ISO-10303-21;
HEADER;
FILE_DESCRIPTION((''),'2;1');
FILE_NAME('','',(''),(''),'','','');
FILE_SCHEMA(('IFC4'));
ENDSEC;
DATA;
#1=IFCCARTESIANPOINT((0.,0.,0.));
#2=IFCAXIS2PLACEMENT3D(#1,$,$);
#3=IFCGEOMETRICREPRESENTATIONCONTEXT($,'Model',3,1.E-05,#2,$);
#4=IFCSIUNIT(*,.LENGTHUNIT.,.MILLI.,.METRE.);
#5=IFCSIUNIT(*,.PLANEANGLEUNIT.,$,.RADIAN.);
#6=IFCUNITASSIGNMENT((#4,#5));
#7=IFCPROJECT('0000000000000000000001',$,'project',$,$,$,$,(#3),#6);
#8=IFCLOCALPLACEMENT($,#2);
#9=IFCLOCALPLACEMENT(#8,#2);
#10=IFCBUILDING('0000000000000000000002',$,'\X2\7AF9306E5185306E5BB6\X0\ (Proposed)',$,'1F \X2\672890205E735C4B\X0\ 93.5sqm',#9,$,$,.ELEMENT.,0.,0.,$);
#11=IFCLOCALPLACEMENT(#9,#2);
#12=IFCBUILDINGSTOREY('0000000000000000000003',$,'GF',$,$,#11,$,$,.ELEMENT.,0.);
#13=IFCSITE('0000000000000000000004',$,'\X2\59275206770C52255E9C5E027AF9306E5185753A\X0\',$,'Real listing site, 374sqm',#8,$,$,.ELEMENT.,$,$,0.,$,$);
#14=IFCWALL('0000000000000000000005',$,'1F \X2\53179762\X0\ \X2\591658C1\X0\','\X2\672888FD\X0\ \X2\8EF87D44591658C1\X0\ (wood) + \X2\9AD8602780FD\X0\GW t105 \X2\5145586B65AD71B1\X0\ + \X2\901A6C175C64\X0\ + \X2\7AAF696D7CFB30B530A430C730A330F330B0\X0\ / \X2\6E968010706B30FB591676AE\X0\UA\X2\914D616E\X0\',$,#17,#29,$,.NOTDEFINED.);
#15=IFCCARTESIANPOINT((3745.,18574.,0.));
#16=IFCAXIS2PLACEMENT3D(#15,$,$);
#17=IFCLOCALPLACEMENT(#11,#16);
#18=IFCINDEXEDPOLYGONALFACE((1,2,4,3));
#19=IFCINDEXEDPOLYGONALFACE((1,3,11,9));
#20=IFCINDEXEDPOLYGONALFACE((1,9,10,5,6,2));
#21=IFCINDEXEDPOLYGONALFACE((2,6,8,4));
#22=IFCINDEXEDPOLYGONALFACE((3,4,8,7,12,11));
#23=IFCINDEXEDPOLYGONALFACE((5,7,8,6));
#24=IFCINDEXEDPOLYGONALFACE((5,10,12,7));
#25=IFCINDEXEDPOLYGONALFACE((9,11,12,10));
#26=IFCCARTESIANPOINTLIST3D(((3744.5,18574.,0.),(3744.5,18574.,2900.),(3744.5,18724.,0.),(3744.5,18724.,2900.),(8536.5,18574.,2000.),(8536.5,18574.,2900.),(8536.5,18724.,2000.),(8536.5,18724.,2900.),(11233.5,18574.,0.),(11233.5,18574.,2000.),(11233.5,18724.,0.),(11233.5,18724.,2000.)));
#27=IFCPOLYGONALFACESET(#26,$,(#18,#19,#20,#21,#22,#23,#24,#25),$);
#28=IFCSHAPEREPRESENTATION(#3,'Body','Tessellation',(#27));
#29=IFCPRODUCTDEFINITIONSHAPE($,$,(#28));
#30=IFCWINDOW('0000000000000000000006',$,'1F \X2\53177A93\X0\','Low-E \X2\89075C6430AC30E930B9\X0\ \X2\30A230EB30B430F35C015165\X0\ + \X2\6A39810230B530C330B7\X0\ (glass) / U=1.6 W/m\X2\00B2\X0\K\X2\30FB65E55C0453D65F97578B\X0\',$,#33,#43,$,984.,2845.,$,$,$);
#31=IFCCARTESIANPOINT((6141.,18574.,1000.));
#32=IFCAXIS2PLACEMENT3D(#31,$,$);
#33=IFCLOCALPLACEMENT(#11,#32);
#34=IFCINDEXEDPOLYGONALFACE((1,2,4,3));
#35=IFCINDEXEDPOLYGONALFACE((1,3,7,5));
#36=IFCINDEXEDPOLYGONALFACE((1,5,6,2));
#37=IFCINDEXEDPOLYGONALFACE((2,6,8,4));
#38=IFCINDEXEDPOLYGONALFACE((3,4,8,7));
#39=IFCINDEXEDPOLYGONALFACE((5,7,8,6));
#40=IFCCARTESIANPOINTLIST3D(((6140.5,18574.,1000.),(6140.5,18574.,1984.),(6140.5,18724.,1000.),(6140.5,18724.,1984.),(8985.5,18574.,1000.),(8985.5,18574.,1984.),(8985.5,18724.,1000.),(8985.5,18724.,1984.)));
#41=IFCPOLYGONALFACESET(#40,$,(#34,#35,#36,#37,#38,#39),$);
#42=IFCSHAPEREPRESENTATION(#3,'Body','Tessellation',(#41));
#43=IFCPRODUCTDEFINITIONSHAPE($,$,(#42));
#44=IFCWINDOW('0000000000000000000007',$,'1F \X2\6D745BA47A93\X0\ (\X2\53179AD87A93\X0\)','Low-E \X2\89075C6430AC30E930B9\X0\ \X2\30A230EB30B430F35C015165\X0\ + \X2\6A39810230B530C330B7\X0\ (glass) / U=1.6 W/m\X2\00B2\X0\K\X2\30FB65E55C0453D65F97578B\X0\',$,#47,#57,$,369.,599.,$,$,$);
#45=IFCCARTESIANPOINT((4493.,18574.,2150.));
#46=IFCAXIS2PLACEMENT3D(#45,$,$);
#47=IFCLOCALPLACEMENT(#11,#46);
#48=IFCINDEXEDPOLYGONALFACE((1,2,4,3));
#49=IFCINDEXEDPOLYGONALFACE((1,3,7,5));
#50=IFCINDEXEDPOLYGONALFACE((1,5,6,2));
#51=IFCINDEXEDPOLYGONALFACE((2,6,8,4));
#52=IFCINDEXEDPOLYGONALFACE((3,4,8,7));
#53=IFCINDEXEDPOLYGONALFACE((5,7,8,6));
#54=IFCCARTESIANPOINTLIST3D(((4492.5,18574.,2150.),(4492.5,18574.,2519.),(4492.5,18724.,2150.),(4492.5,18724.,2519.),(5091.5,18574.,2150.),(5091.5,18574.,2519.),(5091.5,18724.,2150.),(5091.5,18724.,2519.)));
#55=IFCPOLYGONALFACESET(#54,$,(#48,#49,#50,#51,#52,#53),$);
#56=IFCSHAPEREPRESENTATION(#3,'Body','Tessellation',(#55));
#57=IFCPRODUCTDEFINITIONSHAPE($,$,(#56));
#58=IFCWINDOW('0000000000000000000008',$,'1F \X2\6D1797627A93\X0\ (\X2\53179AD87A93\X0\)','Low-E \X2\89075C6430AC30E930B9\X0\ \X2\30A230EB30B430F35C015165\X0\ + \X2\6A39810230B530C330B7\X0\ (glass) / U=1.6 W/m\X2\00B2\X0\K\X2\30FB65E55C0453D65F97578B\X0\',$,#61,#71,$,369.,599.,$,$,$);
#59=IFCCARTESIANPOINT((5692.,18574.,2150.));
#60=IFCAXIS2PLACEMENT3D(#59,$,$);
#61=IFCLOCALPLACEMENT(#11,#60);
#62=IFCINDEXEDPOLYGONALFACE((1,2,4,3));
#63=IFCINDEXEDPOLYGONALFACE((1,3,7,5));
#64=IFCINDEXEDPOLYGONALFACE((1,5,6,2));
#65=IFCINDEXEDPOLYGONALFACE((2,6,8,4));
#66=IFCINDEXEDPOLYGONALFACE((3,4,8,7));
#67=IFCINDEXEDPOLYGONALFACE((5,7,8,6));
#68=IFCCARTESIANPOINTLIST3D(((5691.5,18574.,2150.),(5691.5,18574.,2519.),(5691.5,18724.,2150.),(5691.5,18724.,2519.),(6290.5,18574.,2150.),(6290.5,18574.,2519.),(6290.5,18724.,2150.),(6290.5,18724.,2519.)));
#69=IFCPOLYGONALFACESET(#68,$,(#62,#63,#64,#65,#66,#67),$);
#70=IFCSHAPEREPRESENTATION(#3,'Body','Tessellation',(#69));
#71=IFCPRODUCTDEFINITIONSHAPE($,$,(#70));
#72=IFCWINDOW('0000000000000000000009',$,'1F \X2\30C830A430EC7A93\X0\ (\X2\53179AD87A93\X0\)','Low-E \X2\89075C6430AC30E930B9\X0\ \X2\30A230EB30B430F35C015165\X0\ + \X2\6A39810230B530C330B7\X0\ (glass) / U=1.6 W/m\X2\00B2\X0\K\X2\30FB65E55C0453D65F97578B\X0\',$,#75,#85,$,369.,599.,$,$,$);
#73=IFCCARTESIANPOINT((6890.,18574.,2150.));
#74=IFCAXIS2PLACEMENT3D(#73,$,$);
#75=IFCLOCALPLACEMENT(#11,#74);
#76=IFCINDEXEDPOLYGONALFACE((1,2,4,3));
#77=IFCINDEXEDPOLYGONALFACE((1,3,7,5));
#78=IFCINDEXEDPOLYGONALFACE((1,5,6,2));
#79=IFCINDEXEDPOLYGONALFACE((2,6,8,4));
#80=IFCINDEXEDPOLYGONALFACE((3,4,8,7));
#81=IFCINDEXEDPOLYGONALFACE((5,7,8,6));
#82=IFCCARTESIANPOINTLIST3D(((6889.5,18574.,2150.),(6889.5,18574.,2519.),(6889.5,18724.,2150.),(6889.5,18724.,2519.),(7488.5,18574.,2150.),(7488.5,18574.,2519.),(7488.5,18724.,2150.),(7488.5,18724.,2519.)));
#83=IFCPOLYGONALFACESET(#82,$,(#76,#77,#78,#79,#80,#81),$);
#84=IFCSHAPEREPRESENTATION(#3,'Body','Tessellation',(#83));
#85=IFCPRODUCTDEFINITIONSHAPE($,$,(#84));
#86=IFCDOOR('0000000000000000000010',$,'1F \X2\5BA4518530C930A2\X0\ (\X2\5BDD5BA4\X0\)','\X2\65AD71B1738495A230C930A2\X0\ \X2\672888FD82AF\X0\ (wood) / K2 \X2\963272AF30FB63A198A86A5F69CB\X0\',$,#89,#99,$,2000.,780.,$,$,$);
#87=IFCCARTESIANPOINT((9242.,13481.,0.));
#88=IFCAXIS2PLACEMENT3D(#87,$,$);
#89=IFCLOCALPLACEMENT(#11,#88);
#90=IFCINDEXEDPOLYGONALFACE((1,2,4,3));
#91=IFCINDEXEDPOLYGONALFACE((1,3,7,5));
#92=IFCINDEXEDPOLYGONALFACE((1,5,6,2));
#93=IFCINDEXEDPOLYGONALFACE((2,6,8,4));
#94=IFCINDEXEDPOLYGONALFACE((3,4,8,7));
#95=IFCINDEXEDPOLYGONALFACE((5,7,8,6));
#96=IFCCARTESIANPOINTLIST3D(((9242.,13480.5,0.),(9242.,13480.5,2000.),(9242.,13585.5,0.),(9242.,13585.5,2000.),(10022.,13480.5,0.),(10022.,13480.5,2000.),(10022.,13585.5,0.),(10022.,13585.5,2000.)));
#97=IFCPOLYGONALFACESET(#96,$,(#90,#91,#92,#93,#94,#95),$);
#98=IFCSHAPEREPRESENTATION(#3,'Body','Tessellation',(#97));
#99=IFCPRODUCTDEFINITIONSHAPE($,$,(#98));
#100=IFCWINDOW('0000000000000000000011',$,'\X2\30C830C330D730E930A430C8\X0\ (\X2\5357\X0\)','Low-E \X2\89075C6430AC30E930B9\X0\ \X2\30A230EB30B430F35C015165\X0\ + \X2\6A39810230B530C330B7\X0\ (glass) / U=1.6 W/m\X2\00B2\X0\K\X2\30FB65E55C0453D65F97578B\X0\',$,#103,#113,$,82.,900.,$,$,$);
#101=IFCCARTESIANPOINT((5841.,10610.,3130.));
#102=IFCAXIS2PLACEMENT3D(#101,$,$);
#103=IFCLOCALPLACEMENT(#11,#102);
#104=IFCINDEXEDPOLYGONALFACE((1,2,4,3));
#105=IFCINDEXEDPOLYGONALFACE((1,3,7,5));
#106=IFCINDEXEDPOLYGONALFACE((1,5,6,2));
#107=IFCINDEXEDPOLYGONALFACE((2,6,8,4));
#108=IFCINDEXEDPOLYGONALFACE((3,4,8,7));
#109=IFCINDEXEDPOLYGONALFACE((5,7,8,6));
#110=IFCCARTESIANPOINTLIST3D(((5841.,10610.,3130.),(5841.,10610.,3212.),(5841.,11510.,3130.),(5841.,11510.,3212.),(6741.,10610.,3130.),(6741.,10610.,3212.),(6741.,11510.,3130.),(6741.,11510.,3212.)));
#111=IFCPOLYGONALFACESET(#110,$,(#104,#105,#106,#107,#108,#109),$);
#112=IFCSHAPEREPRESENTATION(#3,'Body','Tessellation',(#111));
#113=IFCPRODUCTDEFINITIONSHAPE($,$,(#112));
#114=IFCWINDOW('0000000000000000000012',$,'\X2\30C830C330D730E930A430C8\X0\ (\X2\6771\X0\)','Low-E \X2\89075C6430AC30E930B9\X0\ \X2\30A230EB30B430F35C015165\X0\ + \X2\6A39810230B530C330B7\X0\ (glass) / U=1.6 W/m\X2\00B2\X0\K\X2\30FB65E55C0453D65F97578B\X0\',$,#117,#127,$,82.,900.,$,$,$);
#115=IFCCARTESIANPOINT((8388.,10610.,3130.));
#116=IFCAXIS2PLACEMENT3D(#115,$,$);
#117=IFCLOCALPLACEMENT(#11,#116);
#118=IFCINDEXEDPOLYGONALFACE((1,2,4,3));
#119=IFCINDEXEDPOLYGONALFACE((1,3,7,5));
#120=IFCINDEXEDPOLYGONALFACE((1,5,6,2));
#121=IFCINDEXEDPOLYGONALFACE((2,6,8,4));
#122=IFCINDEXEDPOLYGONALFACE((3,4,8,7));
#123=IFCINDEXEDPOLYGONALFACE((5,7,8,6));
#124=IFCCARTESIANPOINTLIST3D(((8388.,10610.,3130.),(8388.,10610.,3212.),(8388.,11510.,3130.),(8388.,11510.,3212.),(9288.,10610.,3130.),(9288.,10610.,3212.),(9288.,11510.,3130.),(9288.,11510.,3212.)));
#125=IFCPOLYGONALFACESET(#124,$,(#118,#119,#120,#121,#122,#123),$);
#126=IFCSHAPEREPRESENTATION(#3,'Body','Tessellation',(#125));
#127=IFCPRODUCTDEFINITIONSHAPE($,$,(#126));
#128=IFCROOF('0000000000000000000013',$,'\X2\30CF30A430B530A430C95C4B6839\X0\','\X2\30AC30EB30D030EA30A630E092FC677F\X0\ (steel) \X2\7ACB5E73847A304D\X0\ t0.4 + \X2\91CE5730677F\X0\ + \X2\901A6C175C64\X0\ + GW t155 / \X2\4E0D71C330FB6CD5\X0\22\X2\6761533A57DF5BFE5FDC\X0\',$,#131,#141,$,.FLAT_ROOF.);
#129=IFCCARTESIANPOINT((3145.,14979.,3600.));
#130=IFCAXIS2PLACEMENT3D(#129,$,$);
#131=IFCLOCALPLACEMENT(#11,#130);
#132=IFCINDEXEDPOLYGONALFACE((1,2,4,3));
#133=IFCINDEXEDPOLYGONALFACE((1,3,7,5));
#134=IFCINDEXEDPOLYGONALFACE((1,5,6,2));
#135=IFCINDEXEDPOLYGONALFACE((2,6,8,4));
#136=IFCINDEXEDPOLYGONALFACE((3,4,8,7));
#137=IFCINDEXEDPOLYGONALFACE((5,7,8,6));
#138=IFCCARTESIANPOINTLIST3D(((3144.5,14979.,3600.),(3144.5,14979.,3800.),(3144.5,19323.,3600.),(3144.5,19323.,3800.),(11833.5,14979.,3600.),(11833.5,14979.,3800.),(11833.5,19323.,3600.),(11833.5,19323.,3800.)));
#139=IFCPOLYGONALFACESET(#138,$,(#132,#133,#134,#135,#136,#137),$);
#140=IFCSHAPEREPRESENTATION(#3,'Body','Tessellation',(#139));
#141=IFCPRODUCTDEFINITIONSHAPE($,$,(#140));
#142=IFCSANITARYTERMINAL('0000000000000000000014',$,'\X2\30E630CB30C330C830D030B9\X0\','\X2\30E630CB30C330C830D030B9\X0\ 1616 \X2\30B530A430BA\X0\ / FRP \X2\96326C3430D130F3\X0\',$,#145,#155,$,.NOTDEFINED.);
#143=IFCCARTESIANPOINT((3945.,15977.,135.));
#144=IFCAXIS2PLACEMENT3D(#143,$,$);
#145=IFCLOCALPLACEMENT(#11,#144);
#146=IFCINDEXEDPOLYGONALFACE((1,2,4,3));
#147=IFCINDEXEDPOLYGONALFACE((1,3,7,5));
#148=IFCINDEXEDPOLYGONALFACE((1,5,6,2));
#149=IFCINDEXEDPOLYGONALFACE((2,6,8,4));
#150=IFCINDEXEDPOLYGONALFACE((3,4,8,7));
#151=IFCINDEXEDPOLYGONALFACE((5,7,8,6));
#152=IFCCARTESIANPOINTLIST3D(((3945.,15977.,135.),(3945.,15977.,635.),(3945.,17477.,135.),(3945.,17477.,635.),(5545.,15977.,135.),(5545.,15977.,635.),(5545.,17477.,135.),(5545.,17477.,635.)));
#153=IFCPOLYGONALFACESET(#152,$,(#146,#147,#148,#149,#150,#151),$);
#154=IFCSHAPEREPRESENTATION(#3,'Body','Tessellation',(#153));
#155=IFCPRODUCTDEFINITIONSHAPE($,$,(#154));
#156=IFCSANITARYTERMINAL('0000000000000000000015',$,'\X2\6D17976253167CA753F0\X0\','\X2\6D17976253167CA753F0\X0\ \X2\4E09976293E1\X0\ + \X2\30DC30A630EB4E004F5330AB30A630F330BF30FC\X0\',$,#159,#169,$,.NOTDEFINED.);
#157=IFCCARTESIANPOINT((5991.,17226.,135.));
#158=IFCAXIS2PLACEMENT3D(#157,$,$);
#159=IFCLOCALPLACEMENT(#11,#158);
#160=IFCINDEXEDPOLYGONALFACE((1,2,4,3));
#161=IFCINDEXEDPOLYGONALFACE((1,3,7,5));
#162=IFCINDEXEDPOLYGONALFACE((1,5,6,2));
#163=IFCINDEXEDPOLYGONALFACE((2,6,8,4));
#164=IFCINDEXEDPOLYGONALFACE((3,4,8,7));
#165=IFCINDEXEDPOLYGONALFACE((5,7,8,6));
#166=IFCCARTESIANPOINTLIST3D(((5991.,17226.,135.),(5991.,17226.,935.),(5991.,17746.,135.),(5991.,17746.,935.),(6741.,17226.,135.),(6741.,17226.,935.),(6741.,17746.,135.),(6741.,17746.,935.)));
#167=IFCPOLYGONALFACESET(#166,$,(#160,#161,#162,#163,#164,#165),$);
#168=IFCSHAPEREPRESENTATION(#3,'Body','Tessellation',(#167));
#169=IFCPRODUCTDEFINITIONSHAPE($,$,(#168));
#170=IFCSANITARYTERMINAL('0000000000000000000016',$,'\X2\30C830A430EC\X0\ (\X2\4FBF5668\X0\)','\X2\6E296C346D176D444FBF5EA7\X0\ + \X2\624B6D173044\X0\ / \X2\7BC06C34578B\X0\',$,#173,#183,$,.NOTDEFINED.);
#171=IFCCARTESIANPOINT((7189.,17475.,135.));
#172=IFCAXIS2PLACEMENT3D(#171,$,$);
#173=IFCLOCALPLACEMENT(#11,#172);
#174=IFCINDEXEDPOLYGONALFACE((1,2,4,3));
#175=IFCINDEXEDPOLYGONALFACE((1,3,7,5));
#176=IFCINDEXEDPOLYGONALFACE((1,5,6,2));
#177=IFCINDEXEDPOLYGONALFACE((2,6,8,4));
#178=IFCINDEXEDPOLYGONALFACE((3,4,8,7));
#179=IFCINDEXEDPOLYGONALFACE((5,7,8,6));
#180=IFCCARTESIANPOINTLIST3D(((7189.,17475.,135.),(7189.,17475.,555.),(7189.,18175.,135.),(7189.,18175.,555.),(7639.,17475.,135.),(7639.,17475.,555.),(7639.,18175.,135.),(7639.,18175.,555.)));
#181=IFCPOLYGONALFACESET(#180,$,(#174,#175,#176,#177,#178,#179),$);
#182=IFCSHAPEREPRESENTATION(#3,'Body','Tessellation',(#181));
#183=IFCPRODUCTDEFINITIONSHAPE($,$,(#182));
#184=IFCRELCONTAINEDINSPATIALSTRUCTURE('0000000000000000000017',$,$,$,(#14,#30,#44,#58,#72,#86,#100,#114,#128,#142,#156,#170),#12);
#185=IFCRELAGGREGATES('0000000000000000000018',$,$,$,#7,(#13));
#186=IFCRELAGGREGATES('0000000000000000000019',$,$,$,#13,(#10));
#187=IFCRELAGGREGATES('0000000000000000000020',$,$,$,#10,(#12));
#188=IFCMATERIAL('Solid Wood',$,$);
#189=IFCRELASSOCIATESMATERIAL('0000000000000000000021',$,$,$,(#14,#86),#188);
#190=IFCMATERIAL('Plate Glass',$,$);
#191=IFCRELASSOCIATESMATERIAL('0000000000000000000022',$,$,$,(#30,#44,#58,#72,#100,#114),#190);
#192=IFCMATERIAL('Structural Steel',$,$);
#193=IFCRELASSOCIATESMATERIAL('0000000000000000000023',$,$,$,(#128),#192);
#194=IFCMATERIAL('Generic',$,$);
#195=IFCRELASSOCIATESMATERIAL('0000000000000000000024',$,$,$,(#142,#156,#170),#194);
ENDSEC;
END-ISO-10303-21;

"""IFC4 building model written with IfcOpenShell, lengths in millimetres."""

from ifc_helpers import new_model, si_unit, frame, frame_2d, origin, place, context, project, spatial, rectangle, extrude, material, element, fill, save


model = new_model("IFC4")

# Units and contexts
model_context = context("Model", 3, precision=1e-05, world=origin())
ifc_project = project(units=[si_unit("LENGTHUNIT", "METRE", prefix="MILLI"), si_unit("PLANEANGLEUNIT", "RADIAN")], contexts=[model_context])

# Site, building, storey
site_placement = place(None, origin())
site = spatial("IfcSite", under=ifc_project, at=site_placement, Name="大分県別府市竹の内町", ObjectType="Real listing site, 374sqm", CompositionType="ELEMENT", RefElevation=0.0)
building_placement = place(site_placement, origin())
building = spatial("IfcBuilding", under=site, at=building_placement, Name="竹の内の家 (Proposed)", ObjectType="1F 木造平屋 93.5sqm", CompositionType="ELEMENT", ElevationOfRefHeight=0.0, ElevationOfTerrain=0.0)
storey_placement = place(building_placement, origin())
storey = spatial("IfcBuildingStorey", under=building, at=storey_placement, Name="GF", CompositionType="ELEMENT", Elevation=0.0)

# Shared definitions
ifc_material_1 = material(Name="Solid Wood")

# Wall, openings, windows
wall_1_placement = place(storey_placement, frame((3745.0, 18574.0, 0.0)))
wall_1 = element("IfcWall", 1, at=wall_1_placement, inside=storey, material=ifc_material_1, Name="1F 北面 外壁", Description="木製 軸組外壁 (wood) + 高性能GW t105 充填断熱 + 通気層 + 窯業系サイディング / 準耐火・外皮UA配慮", PredefinedType="NOTDEFINED", context=model_context, shape_type="SweptSolid", body=[
    extrude(rectangle(XDim=7489.0, YDim=150.0, at=frame_2d((3744.0, 75.0))), frame((3745.0, 18574.0, 0.0)), (0.0, 0.0, 1.0), 2900.0),
])
opening_1_placement = place(storey_placement, frame((6141.0, 18574.0, 1000.0)))
opening_1 = element("IfcOpeningElement", 2, at=opening_1_placement, cuts=wall_1, PredefinedType="NOTDEFINED", context=model_context, shape_type="SweptSolid", body=[
    extrude(rectangle(XDim=2845.0, YDim=150.0, at=frame_2d((1422.0, 75.0))), frame((6141.0, 18574.0, 1000.0)), (0.0, 0.0, 1.0), 984.0),
])
opening_2_placement = place(storey_placement, frame((4493.0, 18574.0, 2150.0)))
opening_2 = element("IfcOpeningElement", 3, at=opening_2_placement, cuts=wall_1, PredefinedType="NOTDEFINED", context=model_context, shape_type="SweptSolid", body=[
    extrude(rectangle(XDim=599.0, YDim=150.0, at=frame_2d((299.0, 75.0))), frame((4493.0, 18574.0, 2150.0)), (0.0, 0.0, 1.0), 369.0),
])
opening_3_placement = place(storey_placement, frame((5692.0, 18574.0, 2150.0)))
opening_3 = element("IfcOpeningElement", 4, at=opening_3_placement, cuts=wall_1, PredefinedType="NOTDEFINED", context=model_context, shape_type="SweptSolid", body=[
    extrude(rectangle(XDim=599.0, YDim=150.0, at=frame_2d((299.0, 75.0))), frame((5692.0, 18574.0, 2150.0)), (0.0, 0.0, 1.0), 369.0),
])
opening_4_placement = place(storey_placement, frame((6890.0, 18574.0, 2150.0)))
opening_4 = element("IfcOpeningElement", 5, at=opening_4_placement, cuts=wall_1, PredefinedType="NOTDEFINED", context=model_context, shape_type="SweptSolid", body=[
    extrude(rectangle(XDim=599.0, YDim=150.0, at=frame_2d((299.0, 75.0))), frame((6890.0, 18574.0, 2150.0)), (0.0, 0.0, 1.0), 369.0),
])
ifc_material_2 = material(Name="Plate Glass")
window_1_placement = place(storey_placement, frame((6141.0, 18574.0, 1000.0)))
window_1 = element("IfcWindow", 6, at=window_1_placement, inside=storey, material=ifc_material_2, Name="1F 北窓", Description="Low-E 複層ガラス アルゴン封入 + 樹脂サッシ (glass) / U=1.6 W/m²K・日射取得型", OverallHeight=984.0, OverallWidth=2845.0, context=model_context, shape_type="SweptSolid", body=[
    extrude(rectangle(XDim=2845.0, YDim=150.0, at=frame_2d((1422.0, 75.0))), frame((6141.0, 18574.0, 1000.0)), (0.0, 0.0, 1.0), 984.0),
])
fill(opening_1, window_1)
window_2_placement = place(storey_placement, frame((4493.0, 18574.0, 2150.0)))
window_2 = element("IfcWindow", 7, at=window_2_placement, inside=storey, material=ifc_material_2, Name="1F 浴室窓 (北高窓)", Description="Low-E 複層ガラス アルゴン封入 + 樹脂サッシ (glass) / U=1.6 W/m²K・日射取得型", OverallHeight=369.0, OverallWidth=599.0, context=model_context, shape_type="SweptSolid", body=[
    extrude(rectangle(XDim=599.0, YDim=150.0, at=frame_2d((299.0, 75.0))), frame((4493.0, 18574.0, 2150.0)), (0.0, 0.0, 1.0), 369.0),
])
fill(opening_2, window_2)
window_3_placement = place(storey_placement, frame((5692.0, 18574.0, 2150.0)))
window_3 = element("IfcWindow", 8, at=window_3_placement, inside=storey, material=ifc_material_2, Name="1F 洗面窓 (北高窓)", Description="Low-E 複層ガラス アルゴン封入 + 樹脂サッシ (glass) / U=1.6 W/m²K・日射取得型", OverallHeight=369.0, OverallWidth=599.0, context=model_context, shape_type="SweptSolid", body=[
    extrude(rectangle(XDim=599.0, YDim=150.0, at=frame_2d((299.0, 75.0))), frame((5692.0, 18574.0, 2150.0)), (0.0, 0.0, 1.0), 369.0),
])
fill(opening_3, window_3)
window_4_placement = place(storey_placement, frame((6890.0, 18574.0, 2150.0)))
window_4 = element("IfcWindow", 9, at=window_4_placement, inside=storey, material=ifc_material_2, Name="1F トイレ窓 (北高窓)", Description="Low-E 複層ガラス アルゴン封入 + 樹脂サッシ (glass) / U=1.6 W/m²K・日射取得型", OverallHeight=369.0, OverallWidth=599.0, context=model_context, shape_type="SweptSolid", body=[
    extrude(rectangle(XDim=599.0, YDim=150.0, at=frame_2d((299.0, 75.0))), frame((6890.0, 18574.0, 2150.0)), (0.0, 0.0, 1.0), 369.0),
])
fill(opening_4, window_4)

# Door
door_1_placement = place(storey_placement, frame((9242.0, 13481.0, 0.0)))
element("IfcDoor", 10, at=door_1_placement, inside=storey, material=ifc_material_1, Name="1F 室内ドア (寝室)", Description="断熱玄関ドア 木製芯 (wood) / K2 防犯・採風機構", OverallHeight=2000.0, OverallWidth=780.0, context=model_context, shape_type="SweptSolid", body=[
    extrude(rectangle(XDim=780.0, YDim=105.0, at=frame_2d((390.0, 52.0))), frame((9242.0, 13481.0, 0.0)), (0.0, 0.0, 1.0), 2000.0),
])

# Windows
window_5_placement = place(storey_placement, frame((5841.0, 10610.0, 3130.0)))
element("IfcWindow", 11, at=window_5_placement, inside=storey, material=ifc_material_2, Name="トップライト (南)", Description="Low-E 複層ガラス アルゴン封入 + 樹脂サッシ (glass) / U=1.6 W/m²K・日射取得型", OverallHeight=82.0, OverallWidth=900.0, context=model_context, shape_type="SweptSolid", body=[
    extrude(rectangle(XDim=900.0, YDim=900.0, at=frame_2d((450.0, 450.0))), frame((5841.0, 10610.0, 3130.0)), (0.0, 0.0, 1.0), 82.0),
])
window_6_placement = place(storey_placement, frame((8388.0, 10610.0, 3130.0)))
element("IfcWindow", 12, at=window_6_placement, inside=storey, material=ifc_material_2, Name="トップライト (東)", Description="Low-E 複層ガラス アルゴン封入 + 樹脂サッシ (glass) / U=1.6 W/m²K・日射取得型", OverallHeight=82.0, OverallWidth=900.0, context=model_context, shape_type="SweptSolid", body=[
    extrude(rectangle(XDim=900.0, YDim=900.0, at=frame_2d((450.0, 450.0))), frame((8388.0, 10610.0, 3130.0)), (0.0, 0.0, 1.0), 82.0),
])

# Roof
ifc_material_3 = material(Name="Structural Steel")
roof_placement = place(storey_placement, frame((3145.0, 14979.0, 3600.0)))
element("IfcRoof", 13, at=roof_placement, inside=storey, material=ifc_material_3, Name="ハイサイド屋根", Description="ガルバリウム鋼板 (steel) 立平葺き t0.4 + 野地板 + 通気層 + GW t155 / 不燃・法22条区域対応", PredefinedType="FLAT_ROOF", context=model_context, shape_type="SweptSolid", body=[
    extrude(rectangle(XDim=8689.0, YDim=4344.0, at=frame_2d((4344.0, 2172.0))), frame((3145.0, 14979.0, 3600.0)), (0.0, 0.0, 1.0), 200.0),
])

# Sanitary terminals
ifc_material_4 = material(Name="Generic")
sanitary_terminal_1_placement = place(storey_placement, frame((3945.0, 15977.0, 135.0)))
element("IfcSanitaryTerminal", 14, at=sanitary_terminal_1_placement, inside=storey, material=ifc_material_4, Name="ユニットバス", Description="ユニットバス 1616 サイズ / FRP 防水パン", PredefinedType="NOTDEFINED", context=model_context, shape_type="SweptSolid", body=[
    extrude(rectangle(XDim=1600.0, YDim=1500.0, at=frame_2d((800.0, 750.0))), frame((3945.0, 15977.0, 135.0)), (0.0, 0.0, 1.0), 500.0),
])
sanitary_terminal_2_placement = place(storey_placement, frame((5991.0, 17226.0, 135.0)))
element("IfcSanitaryTerminal", 15, at=sanitary_terminal_2_placement, inside=storey, material=ifc_material_4, Name="洗面化粧台", Description="洗面化粧台 三面鏡 + ボウル一体カウンター", PredefinedType="NOTDEFINED", context=model_context, shape_type="SweptSolid", body=[
    extrude(rectangle(XDim=750.0, YDim=520.0, at=frame_2d((375.0, 260.0))), frame((5991.0, 17226.0, 135.0)), (0.0, 0.0, 1.0), 800.0),
])
sanitary_terminal_3_placement = place(storey_placement, frame((7189.0, 17475.0, 135.0)))
element("IfcSanitaryTerminal", 16, at=sanitary_terminal_3_placement, inside=storey, material=ifc_material_4, Name="トイレ (便器)", Description="温水洗浄便座 + 手洗い / 節水型", PredefinedType="NOTDEFINED", context=model_context, shape_type="SweptSolid", body=[
    extrude(rectangle(XDim=450.0, YDim=700.0, at=frame_2d((225.0, 350.0))), frame((7189.0, 17475.0, 135.0)), (0.0, 0.0, 1.0), 420.0),
])

save(model, "model.ifc")
